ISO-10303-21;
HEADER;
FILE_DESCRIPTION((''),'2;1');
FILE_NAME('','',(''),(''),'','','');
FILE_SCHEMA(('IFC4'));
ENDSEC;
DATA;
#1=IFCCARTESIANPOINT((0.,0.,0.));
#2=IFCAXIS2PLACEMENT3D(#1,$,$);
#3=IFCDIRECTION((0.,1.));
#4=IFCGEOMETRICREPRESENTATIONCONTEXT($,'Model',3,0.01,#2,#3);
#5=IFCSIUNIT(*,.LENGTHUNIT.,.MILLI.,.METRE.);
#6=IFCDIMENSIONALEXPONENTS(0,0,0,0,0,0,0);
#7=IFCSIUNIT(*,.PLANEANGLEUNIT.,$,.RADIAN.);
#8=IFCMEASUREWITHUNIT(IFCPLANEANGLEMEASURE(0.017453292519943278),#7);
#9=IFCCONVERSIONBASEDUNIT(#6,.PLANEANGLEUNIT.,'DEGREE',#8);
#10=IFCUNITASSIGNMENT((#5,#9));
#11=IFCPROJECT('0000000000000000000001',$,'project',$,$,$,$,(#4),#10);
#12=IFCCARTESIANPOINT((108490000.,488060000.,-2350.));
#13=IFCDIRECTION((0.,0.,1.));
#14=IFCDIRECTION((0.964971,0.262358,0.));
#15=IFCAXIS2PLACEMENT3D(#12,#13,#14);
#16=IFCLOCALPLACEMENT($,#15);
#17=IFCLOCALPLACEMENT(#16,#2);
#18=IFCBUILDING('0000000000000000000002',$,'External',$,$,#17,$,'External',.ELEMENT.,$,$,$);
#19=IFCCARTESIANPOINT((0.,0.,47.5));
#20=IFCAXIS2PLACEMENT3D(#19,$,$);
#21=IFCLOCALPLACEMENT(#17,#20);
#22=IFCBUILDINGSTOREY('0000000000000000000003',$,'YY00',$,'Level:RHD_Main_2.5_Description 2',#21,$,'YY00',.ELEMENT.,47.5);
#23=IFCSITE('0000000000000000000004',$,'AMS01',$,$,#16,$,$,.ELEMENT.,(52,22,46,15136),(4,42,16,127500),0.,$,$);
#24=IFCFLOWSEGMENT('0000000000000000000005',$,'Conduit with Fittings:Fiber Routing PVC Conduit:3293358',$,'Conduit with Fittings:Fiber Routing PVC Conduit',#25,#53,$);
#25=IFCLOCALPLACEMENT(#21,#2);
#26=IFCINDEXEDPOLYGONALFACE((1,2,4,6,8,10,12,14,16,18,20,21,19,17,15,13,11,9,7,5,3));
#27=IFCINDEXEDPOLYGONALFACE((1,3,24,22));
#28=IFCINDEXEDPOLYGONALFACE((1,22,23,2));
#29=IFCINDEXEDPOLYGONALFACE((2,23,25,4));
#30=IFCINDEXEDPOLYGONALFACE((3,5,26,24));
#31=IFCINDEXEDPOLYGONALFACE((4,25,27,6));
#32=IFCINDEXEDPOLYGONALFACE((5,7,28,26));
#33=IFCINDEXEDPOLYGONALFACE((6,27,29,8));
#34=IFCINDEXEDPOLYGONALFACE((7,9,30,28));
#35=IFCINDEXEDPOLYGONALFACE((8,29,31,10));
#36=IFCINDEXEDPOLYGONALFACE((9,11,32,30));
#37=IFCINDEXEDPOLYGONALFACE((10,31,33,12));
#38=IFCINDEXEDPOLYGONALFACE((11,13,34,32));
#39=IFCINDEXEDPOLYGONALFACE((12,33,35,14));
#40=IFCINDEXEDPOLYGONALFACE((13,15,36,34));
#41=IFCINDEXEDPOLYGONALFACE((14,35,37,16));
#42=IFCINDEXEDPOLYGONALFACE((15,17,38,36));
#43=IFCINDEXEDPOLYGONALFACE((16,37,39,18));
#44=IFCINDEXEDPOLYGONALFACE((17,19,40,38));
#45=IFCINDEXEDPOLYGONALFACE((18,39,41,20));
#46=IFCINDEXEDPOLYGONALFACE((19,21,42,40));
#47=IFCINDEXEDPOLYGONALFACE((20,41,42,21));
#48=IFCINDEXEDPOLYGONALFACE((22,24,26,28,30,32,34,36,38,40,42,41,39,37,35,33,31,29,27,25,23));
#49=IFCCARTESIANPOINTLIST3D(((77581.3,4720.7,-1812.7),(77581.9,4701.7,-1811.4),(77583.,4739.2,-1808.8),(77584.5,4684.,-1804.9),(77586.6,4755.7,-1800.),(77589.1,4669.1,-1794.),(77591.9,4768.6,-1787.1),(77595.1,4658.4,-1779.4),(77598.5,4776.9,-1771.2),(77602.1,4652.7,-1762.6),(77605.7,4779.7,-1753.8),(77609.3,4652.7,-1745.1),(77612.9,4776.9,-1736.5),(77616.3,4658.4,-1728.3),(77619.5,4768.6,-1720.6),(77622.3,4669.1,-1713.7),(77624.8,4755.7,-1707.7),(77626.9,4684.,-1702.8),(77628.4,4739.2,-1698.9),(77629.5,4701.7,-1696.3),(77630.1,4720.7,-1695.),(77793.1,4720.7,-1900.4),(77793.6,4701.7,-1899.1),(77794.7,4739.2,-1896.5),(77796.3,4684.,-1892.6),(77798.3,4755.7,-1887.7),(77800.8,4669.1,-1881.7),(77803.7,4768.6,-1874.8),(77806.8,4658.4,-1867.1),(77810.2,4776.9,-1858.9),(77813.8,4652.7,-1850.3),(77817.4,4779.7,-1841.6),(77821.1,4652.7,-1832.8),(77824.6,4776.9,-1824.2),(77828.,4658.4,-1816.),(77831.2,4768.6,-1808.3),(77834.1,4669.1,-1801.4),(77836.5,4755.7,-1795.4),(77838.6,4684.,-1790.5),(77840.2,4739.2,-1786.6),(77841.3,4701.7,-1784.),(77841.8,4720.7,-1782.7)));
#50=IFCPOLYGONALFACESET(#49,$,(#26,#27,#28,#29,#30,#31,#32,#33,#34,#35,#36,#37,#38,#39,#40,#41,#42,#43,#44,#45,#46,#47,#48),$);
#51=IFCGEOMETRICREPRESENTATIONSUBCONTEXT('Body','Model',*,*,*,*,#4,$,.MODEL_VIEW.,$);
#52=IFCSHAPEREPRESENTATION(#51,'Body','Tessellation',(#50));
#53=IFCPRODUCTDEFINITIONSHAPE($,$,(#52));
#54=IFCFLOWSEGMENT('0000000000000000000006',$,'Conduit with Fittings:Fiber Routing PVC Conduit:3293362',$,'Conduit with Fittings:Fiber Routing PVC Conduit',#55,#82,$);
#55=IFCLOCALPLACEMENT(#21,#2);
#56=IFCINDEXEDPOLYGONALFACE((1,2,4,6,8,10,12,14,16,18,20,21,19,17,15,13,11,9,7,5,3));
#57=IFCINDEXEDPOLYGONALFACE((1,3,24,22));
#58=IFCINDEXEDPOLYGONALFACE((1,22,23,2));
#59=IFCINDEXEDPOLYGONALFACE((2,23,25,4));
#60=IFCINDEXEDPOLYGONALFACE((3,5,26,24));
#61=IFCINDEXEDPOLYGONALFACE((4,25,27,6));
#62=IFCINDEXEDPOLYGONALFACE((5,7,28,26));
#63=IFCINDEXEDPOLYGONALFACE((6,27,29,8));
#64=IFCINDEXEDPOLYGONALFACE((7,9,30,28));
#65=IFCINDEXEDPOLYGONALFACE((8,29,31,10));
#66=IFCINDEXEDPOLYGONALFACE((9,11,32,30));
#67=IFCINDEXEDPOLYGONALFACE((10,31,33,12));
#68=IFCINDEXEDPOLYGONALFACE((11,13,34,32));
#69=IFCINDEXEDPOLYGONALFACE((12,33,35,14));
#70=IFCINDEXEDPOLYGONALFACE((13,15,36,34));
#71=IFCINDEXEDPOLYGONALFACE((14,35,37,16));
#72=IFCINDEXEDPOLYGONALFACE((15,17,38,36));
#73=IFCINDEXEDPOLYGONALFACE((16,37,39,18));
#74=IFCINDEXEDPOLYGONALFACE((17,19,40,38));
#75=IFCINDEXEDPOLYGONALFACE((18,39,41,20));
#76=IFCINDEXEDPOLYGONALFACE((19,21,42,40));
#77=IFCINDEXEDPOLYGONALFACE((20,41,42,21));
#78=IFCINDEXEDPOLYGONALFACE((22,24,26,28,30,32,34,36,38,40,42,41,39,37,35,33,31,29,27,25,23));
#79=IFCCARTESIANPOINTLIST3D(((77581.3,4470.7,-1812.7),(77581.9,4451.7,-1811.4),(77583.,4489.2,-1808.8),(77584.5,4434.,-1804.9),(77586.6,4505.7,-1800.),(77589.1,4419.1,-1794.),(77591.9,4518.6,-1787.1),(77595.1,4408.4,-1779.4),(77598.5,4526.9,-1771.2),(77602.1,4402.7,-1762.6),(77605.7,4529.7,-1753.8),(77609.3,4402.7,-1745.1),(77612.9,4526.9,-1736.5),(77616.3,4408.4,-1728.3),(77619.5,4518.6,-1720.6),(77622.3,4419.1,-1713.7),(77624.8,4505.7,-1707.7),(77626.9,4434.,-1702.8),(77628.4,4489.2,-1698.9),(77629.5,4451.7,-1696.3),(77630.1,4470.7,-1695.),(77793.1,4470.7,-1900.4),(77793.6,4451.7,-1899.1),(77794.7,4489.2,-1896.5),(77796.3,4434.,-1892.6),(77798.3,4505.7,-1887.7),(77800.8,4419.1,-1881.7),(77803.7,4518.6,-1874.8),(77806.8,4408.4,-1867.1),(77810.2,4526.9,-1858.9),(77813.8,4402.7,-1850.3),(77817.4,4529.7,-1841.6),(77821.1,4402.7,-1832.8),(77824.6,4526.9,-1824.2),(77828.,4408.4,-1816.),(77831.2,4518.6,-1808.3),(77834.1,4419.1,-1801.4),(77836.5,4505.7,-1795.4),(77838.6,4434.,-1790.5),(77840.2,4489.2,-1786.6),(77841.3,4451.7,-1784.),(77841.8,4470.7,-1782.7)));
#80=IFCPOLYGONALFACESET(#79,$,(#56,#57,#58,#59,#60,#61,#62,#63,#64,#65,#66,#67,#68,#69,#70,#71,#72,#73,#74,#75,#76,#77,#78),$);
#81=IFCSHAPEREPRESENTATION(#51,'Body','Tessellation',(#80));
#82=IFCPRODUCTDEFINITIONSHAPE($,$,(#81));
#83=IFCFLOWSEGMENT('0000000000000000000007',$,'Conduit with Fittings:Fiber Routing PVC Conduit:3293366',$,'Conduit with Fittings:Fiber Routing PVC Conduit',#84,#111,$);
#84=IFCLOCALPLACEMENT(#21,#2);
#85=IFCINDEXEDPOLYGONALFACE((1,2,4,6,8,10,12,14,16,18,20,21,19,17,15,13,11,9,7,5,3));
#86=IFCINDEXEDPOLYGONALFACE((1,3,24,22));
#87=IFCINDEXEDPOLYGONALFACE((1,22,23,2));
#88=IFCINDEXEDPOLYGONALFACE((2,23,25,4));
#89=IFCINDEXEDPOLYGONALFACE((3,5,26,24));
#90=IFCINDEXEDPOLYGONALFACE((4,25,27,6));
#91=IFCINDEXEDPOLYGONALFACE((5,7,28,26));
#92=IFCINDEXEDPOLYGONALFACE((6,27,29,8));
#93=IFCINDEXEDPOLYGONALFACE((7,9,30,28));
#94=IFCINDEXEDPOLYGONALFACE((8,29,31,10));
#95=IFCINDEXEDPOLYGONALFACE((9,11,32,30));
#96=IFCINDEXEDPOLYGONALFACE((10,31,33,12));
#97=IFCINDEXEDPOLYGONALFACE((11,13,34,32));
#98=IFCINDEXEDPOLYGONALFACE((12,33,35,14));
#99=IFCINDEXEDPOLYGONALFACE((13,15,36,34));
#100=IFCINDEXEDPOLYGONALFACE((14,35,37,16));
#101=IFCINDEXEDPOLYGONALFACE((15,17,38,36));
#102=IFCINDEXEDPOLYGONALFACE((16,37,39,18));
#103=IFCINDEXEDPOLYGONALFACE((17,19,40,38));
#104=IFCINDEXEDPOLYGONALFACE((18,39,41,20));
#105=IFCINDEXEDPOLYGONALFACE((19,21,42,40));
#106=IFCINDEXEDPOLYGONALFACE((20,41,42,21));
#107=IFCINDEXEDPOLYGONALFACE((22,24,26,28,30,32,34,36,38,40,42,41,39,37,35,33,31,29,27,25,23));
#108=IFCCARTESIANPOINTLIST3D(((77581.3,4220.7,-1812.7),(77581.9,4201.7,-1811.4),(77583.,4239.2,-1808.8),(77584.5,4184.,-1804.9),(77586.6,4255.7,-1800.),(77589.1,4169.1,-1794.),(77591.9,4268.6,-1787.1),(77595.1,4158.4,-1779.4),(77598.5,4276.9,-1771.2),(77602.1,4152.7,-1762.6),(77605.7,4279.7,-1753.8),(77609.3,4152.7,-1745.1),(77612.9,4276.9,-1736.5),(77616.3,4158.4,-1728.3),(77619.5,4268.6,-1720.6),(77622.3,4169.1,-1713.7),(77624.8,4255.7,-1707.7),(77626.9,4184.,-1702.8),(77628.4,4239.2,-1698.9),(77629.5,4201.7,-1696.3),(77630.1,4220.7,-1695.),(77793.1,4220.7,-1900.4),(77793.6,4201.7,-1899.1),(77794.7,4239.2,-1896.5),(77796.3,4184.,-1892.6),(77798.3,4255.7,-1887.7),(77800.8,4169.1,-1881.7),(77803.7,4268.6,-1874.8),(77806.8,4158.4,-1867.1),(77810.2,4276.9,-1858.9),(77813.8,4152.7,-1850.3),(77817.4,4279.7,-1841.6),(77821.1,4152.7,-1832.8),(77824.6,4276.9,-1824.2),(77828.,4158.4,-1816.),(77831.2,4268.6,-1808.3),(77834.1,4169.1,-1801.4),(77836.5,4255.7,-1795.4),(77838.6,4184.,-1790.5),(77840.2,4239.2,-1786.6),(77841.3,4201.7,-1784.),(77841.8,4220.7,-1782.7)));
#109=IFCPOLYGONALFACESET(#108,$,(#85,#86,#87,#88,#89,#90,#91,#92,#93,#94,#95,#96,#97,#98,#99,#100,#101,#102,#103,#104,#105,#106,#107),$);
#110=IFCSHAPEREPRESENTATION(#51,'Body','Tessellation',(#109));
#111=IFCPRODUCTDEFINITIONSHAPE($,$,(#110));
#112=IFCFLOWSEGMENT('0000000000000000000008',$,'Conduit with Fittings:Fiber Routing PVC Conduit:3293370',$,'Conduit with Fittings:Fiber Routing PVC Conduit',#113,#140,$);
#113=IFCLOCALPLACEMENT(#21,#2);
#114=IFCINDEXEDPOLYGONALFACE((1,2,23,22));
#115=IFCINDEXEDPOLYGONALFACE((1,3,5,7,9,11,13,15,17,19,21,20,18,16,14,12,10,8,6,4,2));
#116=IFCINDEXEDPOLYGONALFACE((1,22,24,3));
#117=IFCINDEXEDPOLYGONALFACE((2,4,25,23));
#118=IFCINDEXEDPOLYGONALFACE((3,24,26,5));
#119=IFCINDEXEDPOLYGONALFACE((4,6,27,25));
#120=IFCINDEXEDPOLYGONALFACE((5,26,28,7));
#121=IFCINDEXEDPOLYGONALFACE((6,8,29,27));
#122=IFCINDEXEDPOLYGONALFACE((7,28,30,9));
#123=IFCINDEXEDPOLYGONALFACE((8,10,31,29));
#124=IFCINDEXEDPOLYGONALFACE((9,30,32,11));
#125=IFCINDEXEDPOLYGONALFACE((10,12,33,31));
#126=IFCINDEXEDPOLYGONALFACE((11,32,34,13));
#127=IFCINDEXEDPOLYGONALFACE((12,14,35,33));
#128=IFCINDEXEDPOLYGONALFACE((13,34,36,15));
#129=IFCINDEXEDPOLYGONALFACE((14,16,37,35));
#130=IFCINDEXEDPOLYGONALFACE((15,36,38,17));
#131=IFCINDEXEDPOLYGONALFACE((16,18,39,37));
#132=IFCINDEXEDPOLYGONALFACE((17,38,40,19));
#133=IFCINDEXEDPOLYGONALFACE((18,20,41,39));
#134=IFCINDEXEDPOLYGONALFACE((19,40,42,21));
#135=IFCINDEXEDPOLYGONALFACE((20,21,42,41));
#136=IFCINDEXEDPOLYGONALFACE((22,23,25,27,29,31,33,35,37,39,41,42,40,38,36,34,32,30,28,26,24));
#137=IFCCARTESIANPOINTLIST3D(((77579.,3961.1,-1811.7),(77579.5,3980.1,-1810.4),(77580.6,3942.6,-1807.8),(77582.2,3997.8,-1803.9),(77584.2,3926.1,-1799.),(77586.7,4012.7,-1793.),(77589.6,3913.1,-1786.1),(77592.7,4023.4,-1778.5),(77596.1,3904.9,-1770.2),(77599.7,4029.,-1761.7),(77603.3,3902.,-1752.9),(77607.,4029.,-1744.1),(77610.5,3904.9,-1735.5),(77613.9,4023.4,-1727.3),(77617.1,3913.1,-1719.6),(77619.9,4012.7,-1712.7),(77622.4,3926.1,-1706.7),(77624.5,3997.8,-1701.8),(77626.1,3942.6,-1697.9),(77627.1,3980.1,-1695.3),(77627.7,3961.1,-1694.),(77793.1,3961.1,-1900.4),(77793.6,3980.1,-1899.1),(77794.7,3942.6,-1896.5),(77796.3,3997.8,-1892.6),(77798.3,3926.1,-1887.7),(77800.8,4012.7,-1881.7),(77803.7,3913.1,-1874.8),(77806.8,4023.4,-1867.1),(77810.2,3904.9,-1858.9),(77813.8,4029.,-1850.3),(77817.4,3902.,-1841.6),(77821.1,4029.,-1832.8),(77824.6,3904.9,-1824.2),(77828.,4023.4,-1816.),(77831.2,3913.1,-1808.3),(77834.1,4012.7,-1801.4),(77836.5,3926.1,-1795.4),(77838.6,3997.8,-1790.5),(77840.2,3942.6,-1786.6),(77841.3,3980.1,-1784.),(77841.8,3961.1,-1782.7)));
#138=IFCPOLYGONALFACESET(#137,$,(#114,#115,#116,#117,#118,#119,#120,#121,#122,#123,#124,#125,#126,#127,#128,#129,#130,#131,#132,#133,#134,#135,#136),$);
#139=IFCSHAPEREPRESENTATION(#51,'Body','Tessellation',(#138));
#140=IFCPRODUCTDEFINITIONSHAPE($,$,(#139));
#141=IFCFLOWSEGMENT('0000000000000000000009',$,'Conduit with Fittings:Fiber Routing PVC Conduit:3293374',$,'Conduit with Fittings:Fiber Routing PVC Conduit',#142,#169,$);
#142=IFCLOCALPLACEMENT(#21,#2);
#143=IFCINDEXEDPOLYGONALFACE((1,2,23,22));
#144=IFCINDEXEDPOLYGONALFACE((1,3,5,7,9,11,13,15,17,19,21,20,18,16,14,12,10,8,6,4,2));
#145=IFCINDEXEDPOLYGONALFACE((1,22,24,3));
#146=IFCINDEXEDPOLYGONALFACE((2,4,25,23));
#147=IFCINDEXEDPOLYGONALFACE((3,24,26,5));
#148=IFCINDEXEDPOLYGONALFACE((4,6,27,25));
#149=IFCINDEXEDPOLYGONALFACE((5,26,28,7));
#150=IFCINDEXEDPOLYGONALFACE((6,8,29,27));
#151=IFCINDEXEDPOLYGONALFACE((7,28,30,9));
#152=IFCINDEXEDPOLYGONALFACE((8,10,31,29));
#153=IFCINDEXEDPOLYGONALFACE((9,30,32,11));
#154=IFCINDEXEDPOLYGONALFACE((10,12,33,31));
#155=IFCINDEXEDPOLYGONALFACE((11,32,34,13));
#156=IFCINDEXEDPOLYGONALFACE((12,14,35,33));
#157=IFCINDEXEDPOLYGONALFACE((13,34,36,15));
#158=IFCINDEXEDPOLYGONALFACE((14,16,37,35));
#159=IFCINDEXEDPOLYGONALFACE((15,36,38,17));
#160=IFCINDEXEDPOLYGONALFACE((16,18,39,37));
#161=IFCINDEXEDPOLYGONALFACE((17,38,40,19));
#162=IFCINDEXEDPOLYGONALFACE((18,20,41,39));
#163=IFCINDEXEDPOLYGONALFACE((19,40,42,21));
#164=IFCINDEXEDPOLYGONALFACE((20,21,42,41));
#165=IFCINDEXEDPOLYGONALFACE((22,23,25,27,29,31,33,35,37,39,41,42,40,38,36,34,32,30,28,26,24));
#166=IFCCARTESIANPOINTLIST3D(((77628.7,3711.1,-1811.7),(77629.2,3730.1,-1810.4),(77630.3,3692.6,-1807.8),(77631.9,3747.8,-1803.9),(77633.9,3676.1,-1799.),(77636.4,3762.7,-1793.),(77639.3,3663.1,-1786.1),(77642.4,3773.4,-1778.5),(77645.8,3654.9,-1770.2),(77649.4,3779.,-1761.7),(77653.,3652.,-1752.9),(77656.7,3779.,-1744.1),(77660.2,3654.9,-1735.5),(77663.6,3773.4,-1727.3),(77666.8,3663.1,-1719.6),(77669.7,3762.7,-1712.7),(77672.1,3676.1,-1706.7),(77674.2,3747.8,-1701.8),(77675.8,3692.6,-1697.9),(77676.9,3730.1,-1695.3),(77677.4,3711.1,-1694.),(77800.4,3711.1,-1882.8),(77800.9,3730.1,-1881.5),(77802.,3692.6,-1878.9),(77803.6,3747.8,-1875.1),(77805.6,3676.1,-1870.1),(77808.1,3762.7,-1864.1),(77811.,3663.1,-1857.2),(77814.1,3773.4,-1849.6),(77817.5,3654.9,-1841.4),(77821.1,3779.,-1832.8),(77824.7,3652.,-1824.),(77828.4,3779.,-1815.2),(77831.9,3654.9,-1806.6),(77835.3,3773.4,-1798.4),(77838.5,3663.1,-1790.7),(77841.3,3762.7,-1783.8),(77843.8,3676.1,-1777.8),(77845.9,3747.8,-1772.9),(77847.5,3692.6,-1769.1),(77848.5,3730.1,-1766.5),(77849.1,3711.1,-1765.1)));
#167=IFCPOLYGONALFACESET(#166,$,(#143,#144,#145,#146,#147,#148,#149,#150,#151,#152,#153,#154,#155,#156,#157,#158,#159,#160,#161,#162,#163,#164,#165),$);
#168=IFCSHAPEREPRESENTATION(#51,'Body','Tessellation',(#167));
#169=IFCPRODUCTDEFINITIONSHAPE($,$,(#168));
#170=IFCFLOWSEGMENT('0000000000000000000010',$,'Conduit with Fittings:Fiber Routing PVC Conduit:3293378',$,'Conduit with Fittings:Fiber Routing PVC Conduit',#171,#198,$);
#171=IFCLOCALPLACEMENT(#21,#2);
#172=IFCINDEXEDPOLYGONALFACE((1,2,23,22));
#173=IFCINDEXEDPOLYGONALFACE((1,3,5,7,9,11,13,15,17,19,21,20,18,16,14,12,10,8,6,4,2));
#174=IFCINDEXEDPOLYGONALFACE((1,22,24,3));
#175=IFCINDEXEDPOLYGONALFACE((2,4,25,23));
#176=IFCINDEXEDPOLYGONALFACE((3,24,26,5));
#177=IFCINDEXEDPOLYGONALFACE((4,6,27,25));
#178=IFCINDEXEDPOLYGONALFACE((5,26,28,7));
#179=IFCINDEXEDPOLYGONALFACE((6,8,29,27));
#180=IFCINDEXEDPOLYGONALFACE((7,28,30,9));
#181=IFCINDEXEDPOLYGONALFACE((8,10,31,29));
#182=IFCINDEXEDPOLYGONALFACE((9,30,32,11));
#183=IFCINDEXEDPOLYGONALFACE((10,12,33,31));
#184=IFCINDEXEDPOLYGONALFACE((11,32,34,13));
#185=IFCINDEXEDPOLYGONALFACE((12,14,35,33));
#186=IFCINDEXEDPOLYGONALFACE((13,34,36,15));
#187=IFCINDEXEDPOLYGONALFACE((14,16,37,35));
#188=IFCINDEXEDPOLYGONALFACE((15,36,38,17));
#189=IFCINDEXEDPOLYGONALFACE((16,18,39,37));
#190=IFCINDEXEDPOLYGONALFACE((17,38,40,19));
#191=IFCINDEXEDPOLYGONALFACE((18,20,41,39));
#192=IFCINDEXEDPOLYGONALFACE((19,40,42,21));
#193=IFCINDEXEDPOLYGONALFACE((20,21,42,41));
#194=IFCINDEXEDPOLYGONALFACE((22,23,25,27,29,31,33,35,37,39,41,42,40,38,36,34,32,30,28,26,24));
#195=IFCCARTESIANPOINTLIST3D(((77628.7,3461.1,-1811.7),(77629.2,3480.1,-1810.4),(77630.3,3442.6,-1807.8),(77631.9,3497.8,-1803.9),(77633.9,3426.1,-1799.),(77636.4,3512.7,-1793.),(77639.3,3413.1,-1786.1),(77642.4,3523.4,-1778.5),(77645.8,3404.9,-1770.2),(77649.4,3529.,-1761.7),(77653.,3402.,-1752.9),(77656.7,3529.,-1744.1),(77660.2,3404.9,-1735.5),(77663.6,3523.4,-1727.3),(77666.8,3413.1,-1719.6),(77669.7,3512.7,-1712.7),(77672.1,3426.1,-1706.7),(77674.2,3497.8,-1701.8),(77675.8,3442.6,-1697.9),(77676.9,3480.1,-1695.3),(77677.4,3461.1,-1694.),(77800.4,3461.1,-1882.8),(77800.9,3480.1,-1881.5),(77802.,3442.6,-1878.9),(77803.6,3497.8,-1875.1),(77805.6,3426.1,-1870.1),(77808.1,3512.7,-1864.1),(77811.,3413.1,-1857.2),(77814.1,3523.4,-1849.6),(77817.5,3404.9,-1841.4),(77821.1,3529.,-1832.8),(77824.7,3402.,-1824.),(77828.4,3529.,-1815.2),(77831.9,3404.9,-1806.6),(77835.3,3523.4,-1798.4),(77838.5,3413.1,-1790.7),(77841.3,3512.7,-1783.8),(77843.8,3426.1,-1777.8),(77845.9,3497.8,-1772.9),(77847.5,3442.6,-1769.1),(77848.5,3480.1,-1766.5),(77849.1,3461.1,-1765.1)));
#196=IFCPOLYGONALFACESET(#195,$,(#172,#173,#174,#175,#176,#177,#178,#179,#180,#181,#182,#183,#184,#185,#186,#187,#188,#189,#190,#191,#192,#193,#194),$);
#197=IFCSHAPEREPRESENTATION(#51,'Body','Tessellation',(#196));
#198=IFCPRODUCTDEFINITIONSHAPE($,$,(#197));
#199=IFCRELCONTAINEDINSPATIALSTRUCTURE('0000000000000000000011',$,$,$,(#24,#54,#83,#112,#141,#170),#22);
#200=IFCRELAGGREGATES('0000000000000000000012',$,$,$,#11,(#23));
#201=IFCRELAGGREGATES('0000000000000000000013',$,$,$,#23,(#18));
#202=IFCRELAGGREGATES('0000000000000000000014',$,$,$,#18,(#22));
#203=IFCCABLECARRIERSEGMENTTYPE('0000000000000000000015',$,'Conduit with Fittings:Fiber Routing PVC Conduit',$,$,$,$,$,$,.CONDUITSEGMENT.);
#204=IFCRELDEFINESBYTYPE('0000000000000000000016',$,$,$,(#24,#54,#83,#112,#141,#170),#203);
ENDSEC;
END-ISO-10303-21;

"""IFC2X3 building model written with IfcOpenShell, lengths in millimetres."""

from ifc_helpers import new_model, entity, si_unit, converted_unit, direction, frame, frame_2d, origin, place, context, subcontext, project, spatial, circle, extrude, type_object, element, save


model = new_model("IFC2X3")

# Units and contexts
model_context = context("Model", 3, precision=0.01, world=origin(), true_north=direction((0.0, 1.0)))
body_context = subcontext(model_context, "Body", "Model", "MODEL_VIEW")
ifc_project = project(units=[si_unit("LENGTHUNIT", "METRE", prefix="MILLI"), converted_unit("PLANEANGLEUNIT", "DEGREE", entity("IfcPlaneAngleMeasure", 0.017453292519943278), si_unit("PLANEANGLEUNIT", "RADIAN"), dimensions=[0, 0, 0, 0, 0, 0, 0])], contexts=[model_context])

# Site, building, storey
site_placement = place(None, frame((108490000.0, 488060000.0, -2350.0), z_axis=(0.0, 0.0, 1.0), x_axis=(0.964971, 0.262358, 0.0)))
site = spatial("IfcSite", under=ifc_project, at=site_placement, Name="AMS01", CompositionType="ELEMENT", RefLatitude=(52, 22, 46, 15136), RefLongitude=(4, 42, 16, 127500), RefElevation=0.0)
building_placement = place(site_placement, origin())
building = spatial("IfcBuilding", under=site, at=building_placement, Name="External", LongName="External", CompositionType="ELEMENT")
storey_placement = place(building_placement, frame((0.0, 0.0, 47.5)))
storey = spatial("IfcBuildingStorey", under=building, at=storey_placement, Name="YY00", ObjectType="Level:RHD_Main_2.5_Description 2", LongName="YY00", CompositionType="ELEMENT", Elevation=47.5)

# Flow segments
cable_carrier_segment_type = type_object("IfcCableCarrierSegmentType", Name="Conduit with Fittings:Fiber Routing PVC Conduit", PredefinedType="CONDUITSEGMENT")
flow_segment_1_placement = place(storey_placement, origin())
element("IfcFlowSegment", 1, at=flow_segment_1_placement, inside=storey, type_object=cable_carrier_segment_type, Name="Conduit with Fittings:Fiber Routing PVC Conduit:3293358", ObjectType="Conduit with Fittings:Fiber Routing PVC Conduit", context=body_context, shape_type="SweptSolid", body=[
    extrude(circle(Radius=63.9, at=frame_2d((0.0, 0.0), x_axis=(1.0, 0.0))), frame((77605.7, 4715.9, -1753.8), z_axis=(0.92388, 0.0, -0.382683), x_axis=(0.0, 1.0, 0.0)), (0.0, 0.0, 1.0), 229.2),
])
flow_segment_2_placement = place(storey_placement, origin())
element("IfcFlowSegment", 2, at=flow_segment_2_placement, inside=storey, type_object=cable_carrier_segment_type, Name="Conduit with Fittings:Fiber Routing PVC Conduit:3293362", ObjectType="Conduit with Fittings:Fiber Routing PVC Conduit", context=body_context, shape_type="SweptSolid", body=[
    extrude(circle(Radius=63.9, at=frame_2d((0.0, 0.0), x_axis=(1.0, 0.0))), frame((77605.7, 4465.9, -1753.8), z_axis=(0.92388, 0.0, -0.382683), x_axis=(0.0, 1.0, 0.0)), (0.0, 0.0, 1.0), 229.2),
])
flow_segment_3_placement = place(storey_placement, origin())
element("IfcFlowSegment", 3, at=flow_segment_3_placement, inside=storey, type_object=cable_carrier_segment_type, Name="Conduit with Fittings:Fiber Routing PVC Conduit:3293366", ObjectType="Conduit with Fittings:Fiber Routing PVC Conduit", context=body_context, shape_type="SweptSolid", body=[
    extrude(circle(Radius=63.9, at=frame_2d((0.0, 0.0), x_axis=(1.0, 0.0))), frame((77605.7, 4215.9, -1753.8), z_axis=(0.92388, 0.0, -0.382683), x_axis=(0.0, 1.0, 0.0)), (0.0, 0.0, 1.0), 229.2),
])
flow_segment_4_placement = place(storey_placement, origin())
element("IfcFlowSegment", 4, at=flow_segment_4_placement, inside=storey, type_object=cable_carrier_segment_type, Name="Conduit with Fittings:Fiber Routing PVC Conduit:3293370", ObjectType="Conduit with Fittings:Fiber Routing PVC Conduit", context=body_context, shape_type="SweptSolid", body=[
    extrude(circle(Radius=63.9, at=frame_2d((0.0, 0.0), x_axis=(1.0, 0.0))), frame((77817.4, 3965.9, -1841.6), z_axis=(-0.92388, 0.0, 0.382683), x_axis=(0.0, -1.0, 0.0)), (0.0, 0.0, 1.0), 231.8),
])
flow_segment_5_placement = place(storey_placement, origin())
element("IfcFlowSegment", 5, at=flow_segment_5_placement, inside=storey, type_object=cable_carrier_segment_type, Name="Conduit with Fittings:Fiber Routing PVC Conduit:3293374", ObjectType="Conduit with Fittings:Fiber Routing PVC Conduit", context=body_context, shape_type="SweptSolid", body=[
    extrude(circle(Radius=63.9, at=frame_2d((0.0, 0.0), x_axis=(1.0, 0.0))), frame((77653.0, 3715.9, -1752.9), z_axis=(0.92388, 0.0, -0.382683), x_axis=(0.0, -1.0, 0.0)), (0.0, 0.0, 1.0), 185.8),
])
flow_segment_6_placement = place(storey_placement, origin())
element("IfcFlowSegment", 6, at=flow_segment_6_placement, inside=storey, type_object=cable_carrier_segment_type, Name="Conduit with Fittings:Fiber Routing PVC Conduit:3293378", ObjectType="Conduit with Fittings:Fiber Routing PVC Conduit", context=body_context, shape_type="SweptSolid", body=[
    extrude(circle(Radius=63.9, at=frame_2d((0.0, 0.0), x_axis=(1.0, 0.0))), frame((77653.0, 3465.9, -1752.9), z_axis=(0.92388, 0.0, -0.382683), x_axis=(0.0, -1.0, 0.0)), (0.0, 0.0, 1.0), 185.8),
])

save(model, "model.ifc")
